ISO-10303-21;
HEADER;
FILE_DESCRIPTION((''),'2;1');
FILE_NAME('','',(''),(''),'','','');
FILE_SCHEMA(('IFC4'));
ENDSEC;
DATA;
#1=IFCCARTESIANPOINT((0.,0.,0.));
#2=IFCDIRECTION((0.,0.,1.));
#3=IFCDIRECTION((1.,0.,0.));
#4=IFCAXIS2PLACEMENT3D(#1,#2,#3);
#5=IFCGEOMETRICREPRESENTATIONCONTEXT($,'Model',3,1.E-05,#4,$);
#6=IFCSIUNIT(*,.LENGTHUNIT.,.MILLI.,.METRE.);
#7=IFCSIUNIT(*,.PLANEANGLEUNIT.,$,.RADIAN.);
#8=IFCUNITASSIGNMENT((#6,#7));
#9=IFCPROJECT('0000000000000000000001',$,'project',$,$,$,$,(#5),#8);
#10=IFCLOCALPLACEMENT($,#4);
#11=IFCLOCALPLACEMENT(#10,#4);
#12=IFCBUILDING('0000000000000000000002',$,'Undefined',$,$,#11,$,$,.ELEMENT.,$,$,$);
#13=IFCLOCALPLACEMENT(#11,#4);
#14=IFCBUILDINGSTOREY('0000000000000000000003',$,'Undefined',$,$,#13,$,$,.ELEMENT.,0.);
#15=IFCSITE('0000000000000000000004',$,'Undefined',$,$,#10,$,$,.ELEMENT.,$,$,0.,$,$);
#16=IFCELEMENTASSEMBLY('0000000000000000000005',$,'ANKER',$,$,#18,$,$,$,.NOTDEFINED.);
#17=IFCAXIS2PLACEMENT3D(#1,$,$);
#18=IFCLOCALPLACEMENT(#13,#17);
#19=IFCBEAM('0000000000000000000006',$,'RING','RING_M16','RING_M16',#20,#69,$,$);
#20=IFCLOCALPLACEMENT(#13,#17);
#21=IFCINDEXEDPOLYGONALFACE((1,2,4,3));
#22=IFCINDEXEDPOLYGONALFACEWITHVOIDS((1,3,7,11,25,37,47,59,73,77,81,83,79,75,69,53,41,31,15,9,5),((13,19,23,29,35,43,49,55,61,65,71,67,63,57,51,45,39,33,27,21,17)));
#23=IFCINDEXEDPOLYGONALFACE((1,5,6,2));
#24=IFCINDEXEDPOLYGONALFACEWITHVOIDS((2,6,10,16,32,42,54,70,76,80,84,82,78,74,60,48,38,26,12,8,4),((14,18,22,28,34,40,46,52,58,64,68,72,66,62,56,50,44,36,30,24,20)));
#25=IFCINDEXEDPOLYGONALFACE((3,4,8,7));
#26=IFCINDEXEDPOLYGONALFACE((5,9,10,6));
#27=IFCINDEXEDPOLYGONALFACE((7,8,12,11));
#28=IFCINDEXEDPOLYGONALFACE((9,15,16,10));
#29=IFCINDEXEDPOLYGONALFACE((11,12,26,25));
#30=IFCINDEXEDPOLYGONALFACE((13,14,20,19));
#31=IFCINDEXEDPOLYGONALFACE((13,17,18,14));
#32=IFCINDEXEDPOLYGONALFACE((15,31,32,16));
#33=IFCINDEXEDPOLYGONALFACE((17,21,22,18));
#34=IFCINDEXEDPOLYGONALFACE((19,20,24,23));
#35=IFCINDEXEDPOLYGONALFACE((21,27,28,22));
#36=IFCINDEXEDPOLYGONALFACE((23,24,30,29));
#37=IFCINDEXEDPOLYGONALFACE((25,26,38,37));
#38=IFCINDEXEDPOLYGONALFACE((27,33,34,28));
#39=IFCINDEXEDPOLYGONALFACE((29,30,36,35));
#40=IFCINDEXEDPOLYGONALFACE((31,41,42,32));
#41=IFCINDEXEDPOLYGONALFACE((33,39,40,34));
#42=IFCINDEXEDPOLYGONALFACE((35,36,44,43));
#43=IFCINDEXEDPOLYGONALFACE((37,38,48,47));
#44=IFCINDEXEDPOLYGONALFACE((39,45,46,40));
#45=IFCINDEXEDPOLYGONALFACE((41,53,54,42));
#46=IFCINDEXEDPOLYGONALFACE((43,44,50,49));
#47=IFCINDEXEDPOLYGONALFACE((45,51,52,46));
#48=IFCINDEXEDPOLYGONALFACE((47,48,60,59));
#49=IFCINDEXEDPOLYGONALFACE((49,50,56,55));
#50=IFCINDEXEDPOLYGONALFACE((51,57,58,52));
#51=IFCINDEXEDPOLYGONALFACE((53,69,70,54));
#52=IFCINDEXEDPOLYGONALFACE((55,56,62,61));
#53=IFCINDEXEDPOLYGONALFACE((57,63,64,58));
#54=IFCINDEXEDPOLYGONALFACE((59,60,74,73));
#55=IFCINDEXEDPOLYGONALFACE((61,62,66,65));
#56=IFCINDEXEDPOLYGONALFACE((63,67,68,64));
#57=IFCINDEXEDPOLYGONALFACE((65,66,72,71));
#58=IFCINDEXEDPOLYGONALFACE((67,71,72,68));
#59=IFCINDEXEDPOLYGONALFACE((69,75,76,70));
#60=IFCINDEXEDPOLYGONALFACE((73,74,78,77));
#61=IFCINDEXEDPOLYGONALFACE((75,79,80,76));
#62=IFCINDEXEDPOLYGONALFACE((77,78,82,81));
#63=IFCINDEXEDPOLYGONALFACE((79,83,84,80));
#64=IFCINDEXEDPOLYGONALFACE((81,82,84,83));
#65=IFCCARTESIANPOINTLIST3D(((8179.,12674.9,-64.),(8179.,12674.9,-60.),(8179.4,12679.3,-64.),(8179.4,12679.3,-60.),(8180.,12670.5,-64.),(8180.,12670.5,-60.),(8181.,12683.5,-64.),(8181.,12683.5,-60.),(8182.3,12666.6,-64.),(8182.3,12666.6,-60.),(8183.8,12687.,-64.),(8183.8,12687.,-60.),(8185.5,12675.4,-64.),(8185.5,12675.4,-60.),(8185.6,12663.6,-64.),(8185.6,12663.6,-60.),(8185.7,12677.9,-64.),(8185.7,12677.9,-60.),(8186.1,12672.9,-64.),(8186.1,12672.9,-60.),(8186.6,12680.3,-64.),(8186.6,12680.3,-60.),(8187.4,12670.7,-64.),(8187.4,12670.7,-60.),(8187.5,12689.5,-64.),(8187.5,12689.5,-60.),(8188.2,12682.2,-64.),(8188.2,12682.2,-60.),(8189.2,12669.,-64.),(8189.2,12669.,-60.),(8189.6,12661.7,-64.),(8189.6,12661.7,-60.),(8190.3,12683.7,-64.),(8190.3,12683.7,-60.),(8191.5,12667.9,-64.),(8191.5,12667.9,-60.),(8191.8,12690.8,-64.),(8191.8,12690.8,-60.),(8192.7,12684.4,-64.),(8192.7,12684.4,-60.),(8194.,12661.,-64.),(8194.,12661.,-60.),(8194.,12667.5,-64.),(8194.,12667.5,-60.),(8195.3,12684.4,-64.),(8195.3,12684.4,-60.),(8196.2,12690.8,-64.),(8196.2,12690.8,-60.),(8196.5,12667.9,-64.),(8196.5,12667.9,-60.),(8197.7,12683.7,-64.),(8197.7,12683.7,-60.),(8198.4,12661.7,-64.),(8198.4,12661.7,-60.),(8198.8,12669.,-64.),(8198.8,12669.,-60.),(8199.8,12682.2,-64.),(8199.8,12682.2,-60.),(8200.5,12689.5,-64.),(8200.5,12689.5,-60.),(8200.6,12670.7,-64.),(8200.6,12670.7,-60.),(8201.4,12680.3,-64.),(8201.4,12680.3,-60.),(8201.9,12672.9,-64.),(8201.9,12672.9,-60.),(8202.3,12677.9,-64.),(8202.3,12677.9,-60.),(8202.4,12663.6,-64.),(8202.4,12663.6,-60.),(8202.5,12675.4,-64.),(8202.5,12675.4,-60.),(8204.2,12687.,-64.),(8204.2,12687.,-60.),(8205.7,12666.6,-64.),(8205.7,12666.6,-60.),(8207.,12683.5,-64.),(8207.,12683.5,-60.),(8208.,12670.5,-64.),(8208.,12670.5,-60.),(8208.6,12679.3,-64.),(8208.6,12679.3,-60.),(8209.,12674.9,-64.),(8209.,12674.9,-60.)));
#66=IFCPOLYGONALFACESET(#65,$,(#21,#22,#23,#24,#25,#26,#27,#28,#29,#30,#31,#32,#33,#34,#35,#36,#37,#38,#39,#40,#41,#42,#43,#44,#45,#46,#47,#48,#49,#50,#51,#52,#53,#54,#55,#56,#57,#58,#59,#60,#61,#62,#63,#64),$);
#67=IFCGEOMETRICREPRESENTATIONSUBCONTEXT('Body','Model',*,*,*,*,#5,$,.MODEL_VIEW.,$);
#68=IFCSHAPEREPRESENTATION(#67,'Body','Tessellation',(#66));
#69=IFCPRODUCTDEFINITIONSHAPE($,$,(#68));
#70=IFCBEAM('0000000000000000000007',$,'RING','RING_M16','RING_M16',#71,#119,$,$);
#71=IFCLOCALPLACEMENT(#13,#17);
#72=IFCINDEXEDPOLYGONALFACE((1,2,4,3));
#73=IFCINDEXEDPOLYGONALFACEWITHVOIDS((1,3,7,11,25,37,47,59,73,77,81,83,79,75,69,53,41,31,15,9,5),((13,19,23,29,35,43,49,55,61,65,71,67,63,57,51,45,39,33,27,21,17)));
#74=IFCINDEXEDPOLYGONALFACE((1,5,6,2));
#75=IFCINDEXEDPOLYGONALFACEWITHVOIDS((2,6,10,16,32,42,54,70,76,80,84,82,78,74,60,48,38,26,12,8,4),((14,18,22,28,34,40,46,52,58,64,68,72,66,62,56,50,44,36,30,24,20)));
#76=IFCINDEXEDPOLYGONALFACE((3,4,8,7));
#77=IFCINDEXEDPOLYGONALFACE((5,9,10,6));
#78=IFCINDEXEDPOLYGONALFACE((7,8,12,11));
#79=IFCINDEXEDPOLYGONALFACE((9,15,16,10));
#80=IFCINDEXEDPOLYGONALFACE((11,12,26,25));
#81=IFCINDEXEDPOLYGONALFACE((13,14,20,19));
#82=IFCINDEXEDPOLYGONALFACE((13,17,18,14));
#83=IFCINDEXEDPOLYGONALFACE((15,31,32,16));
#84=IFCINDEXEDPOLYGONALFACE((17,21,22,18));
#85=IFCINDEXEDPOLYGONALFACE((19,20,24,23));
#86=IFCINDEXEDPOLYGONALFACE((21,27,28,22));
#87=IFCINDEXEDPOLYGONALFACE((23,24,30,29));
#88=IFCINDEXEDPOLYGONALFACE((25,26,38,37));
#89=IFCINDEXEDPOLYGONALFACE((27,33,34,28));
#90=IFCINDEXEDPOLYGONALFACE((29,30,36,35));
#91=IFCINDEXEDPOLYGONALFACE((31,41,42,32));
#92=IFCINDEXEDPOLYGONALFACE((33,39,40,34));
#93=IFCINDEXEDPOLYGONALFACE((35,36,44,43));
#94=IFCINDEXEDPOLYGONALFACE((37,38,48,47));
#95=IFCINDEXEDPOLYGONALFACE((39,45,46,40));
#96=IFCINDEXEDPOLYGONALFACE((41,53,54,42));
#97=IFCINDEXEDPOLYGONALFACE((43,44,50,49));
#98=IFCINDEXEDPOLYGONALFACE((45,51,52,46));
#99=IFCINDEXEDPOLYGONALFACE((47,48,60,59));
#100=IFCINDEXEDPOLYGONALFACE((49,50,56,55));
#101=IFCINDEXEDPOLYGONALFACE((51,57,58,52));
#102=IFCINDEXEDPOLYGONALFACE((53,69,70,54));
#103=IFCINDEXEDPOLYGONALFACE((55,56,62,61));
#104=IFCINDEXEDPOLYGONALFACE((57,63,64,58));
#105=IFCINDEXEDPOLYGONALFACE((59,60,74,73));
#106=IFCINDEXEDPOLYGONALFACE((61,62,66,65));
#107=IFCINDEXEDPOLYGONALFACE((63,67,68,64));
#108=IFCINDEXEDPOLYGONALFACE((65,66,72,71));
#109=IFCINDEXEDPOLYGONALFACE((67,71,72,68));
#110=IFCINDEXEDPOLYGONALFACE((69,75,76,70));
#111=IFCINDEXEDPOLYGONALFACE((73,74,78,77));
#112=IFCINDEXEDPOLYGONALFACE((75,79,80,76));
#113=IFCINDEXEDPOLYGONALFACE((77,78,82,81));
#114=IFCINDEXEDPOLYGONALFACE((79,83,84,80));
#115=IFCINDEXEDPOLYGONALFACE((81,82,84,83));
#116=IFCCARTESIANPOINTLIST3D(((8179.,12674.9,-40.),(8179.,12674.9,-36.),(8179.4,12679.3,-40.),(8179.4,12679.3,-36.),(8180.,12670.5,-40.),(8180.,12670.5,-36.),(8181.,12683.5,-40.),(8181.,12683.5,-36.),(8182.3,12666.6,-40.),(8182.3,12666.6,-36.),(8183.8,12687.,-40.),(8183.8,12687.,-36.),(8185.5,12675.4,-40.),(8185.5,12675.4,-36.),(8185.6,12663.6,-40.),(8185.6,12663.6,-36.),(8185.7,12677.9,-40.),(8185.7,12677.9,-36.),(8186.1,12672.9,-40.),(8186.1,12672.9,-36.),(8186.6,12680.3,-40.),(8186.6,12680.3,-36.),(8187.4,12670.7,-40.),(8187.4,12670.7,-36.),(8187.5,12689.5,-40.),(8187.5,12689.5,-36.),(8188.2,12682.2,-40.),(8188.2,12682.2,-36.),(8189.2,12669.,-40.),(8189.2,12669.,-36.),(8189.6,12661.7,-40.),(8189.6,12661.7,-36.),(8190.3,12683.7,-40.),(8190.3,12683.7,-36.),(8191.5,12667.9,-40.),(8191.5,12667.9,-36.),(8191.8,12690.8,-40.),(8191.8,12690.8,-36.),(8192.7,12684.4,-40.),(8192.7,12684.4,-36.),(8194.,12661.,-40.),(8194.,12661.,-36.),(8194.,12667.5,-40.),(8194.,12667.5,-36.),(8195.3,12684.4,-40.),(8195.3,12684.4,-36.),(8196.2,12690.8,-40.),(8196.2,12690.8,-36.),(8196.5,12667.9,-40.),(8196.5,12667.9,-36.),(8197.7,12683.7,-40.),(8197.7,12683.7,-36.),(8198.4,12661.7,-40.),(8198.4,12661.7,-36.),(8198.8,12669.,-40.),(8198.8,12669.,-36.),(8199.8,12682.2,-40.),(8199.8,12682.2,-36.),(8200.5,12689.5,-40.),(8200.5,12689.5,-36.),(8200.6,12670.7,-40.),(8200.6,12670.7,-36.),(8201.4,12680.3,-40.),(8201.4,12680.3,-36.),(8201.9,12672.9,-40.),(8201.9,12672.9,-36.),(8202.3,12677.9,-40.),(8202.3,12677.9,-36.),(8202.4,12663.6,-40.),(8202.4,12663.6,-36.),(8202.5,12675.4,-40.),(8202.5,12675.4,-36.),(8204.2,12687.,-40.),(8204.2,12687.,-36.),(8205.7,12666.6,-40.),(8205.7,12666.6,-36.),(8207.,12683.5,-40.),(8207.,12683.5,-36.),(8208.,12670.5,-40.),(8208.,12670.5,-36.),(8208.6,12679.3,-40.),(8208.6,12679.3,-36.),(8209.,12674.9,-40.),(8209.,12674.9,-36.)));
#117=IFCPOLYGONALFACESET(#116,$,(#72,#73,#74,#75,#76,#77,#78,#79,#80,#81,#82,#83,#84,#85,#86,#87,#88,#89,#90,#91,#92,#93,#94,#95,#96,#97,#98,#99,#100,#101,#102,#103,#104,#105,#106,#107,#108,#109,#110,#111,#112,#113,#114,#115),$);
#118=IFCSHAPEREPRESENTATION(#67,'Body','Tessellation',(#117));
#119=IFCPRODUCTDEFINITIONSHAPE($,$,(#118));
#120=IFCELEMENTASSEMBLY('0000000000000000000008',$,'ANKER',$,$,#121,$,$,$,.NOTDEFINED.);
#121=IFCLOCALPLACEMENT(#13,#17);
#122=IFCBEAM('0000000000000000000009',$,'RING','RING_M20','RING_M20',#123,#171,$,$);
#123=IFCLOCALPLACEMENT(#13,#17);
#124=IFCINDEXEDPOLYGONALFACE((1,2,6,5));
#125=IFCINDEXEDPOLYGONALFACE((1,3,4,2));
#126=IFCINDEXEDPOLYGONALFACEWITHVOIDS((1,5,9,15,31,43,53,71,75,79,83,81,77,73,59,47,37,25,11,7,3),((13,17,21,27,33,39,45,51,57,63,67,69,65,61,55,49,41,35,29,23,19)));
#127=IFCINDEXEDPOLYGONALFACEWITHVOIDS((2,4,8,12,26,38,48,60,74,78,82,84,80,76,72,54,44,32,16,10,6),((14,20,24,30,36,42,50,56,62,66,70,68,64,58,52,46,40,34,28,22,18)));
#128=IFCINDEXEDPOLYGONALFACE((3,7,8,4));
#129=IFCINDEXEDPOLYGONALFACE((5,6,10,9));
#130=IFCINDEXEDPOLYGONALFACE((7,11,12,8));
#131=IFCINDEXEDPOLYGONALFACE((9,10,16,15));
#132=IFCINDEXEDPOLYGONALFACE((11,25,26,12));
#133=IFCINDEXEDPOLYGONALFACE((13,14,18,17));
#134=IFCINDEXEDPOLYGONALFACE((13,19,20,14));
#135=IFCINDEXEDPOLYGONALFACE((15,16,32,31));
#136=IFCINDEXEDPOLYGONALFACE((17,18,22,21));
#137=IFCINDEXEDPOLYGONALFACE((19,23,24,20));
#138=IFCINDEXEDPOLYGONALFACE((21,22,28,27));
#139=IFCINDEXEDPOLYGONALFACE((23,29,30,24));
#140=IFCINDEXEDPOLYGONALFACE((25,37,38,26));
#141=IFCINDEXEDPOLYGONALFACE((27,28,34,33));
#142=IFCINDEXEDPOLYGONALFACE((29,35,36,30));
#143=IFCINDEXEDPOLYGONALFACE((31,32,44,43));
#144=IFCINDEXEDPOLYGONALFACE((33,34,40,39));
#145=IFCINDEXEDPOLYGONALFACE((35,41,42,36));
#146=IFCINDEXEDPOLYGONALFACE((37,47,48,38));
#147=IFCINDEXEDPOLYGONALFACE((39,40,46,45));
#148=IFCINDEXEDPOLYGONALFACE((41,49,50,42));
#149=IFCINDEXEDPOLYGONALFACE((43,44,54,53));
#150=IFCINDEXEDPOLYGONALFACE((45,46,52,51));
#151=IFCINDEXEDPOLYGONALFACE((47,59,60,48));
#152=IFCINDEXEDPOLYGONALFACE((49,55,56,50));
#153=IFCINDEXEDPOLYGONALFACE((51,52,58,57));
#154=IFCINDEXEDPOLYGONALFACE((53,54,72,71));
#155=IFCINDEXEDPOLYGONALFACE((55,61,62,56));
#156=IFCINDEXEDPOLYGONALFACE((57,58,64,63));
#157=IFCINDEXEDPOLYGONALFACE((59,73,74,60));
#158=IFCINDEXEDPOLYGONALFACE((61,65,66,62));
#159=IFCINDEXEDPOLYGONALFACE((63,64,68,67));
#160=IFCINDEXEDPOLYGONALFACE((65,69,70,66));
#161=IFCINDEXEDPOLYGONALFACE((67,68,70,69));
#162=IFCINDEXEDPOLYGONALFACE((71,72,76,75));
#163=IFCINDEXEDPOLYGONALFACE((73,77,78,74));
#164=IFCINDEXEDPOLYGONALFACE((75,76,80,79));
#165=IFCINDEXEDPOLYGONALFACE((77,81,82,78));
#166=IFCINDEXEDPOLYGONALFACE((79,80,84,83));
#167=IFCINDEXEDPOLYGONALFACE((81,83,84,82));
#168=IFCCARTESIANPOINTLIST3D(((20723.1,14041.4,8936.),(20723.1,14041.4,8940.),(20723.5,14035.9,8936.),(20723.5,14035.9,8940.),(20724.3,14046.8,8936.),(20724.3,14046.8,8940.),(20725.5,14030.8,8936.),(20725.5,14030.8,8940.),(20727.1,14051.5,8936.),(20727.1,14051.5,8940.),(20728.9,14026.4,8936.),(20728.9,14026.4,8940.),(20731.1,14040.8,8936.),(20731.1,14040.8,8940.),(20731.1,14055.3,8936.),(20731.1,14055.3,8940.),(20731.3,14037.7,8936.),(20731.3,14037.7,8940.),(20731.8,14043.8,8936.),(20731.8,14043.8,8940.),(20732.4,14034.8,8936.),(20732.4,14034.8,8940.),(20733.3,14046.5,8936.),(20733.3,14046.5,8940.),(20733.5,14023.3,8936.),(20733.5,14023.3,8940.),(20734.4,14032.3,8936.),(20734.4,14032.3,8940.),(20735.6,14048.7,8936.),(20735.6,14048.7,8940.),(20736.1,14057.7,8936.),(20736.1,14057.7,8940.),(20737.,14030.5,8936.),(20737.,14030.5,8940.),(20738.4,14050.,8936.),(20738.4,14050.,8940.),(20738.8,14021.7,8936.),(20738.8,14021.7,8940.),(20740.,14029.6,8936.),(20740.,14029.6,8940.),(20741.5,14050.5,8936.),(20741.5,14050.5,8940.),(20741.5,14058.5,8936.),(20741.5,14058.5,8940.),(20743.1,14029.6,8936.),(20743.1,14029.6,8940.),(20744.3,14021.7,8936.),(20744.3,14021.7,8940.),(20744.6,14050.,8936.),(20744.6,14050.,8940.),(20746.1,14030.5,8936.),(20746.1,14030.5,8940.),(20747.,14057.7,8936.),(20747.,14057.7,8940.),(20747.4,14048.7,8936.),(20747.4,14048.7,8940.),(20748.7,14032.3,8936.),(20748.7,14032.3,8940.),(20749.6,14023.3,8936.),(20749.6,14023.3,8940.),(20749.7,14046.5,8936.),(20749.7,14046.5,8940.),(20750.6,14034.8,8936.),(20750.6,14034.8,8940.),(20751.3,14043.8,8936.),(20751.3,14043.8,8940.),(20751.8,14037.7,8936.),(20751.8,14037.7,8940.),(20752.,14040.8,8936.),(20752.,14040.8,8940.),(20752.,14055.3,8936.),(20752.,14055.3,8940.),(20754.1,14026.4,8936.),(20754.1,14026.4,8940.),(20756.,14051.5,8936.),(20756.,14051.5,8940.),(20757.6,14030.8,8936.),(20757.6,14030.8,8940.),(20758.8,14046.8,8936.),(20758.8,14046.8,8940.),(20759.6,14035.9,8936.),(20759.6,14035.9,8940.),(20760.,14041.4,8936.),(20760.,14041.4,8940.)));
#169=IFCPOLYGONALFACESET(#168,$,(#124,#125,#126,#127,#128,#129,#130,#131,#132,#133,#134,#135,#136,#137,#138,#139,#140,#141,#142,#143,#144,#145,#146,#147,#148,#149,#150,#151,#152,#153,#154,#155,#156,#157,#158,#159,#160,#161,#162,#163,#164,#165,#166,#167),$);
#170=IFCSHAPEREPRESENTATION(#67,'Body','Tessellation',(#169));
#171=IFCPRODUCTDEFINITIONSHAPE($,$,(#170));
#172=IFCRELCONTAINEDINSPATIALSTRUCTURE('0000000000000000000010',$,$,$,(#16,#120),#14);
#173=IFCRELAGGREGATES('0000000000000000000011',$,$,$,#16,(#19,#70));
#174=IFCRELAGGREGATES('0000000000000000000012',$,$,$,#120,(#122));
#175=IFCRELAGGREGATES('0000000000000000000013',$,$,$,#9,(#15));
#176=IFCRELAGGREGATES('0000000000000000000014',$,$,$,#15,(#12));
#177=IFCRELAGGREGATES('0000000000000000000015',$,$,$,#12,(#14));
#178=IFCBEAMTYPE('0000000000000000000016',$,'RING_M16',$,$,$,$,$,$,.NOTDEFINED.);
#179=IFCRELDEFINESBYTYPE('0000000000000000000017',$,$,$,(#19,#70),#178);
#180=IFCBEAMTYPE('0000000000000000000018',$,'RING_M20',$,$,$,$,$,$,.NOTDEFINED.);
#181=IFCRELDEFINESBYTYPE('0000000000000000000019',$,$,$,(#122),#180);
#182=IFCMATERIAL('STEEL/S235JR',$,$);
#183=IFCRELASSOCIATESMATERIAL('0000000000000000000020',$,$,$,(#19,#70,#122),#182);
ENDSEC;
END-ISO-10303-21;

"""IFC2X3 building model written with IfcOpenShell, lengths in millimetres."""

from ifc_helpers import new_model, si_unit, frame, origin_with_axes, origin_2d_with_axis, place, context, subcontext, project, spatial, hollow_circle, extrude, material, type_object, element, aggregate, save


model = new_model("IFC2X3")

# Units and contexts
model_context = context("Model", 3, precision=1e-05, world=origin_with_axes())
body_context = subcontext(model_context, "Body", "Model", "MODEL_VIEW")
ifc_project = project(units=[si_unit("LENGTHUNIT", "METRE", prefix="MILLI"), si_unit("PLANEANGLEUNIT", "RADIAN")], contexts=[model_context])

# Site, building, storey
site_placement = place(None, origin_with_axes())
site = spatial("IfcSite", under=ifc_project, at=site_placement, Name="Undefined", CompositionType="ELEMENT", RefElevation=0.0)
building_placement = place(site_placement, origin_with_axes())
building = spatial("IfcBuilding", under=site, at=building_placement, Name="Undefined", CompositionType="ELEMENT")
storey_placement = place(building_placement, origin_with_axes())
storey = spatial("IfcBuildingStorey", under=building, at=storey_placement, Name="Undefined", CompositionType="ELEMENT", Elevation=0.0)

# Shared definitions
ifc_material = material(Name="STEEL/S235JR")

# Element assemblies, beams
beam_type_1 = type_object("IfcBeamType", Name="RING_M16", PredefinedType="NOTDEFINED")
assembly_1_placement = place(storey_placement, frame((8194.0, 12676.0, 10.0), z_axis=(1.0, 0.0, 0.0), x_axis=(0.0, 0.0, -1.0)))
assembly_1 = element("IfcElementAssembly", 1, at=assembly_1_placement, inside=storey, Name="ANKER", PredefinedType="NOTDEFINED")
beam_1_placement = place(storey_placement, frame((8194.0, 12676.0, -60.0), z_axis=(1.0, 0.0, 0.0), x_axis=(0.0, 0.0, -1.0)))
beam_1 = element("IfcBeam", 2, at=beam_1_placement, type_object=beam_type_1, material=ifc_material, Name="RING", Description="RING_M16", ObjectType="RING_M16", context=body_context, shape_type="SweptSolid", body=[
    extrude(hollow_circle(Radius=15.0, WallThickness=6.5, at=origin_2d_with_axis()), frame((4.0, 0.0, 0.0), z_axis=(-1.0, 0.0, 0.0), x_axis=(0.0, -1.0, 0.0)), (0.0, 0.0, 1.0), 4.0),
])
beam_2_placement = place(storey_placement, frame((8194.0, 12676.0, -36.0), z_axis=(1.0, 0.0, 0.0), x_axis=(0.0, 0.0, -1.0)))
beam_2 = element("IfcBeam", 3, at=beam_2_placement, type_object=beam_type_1, material=ifc_material, Name="RING", Description="RING_M16", ObjectType="RING_M16", context=body_context, shape_type="SweptSolid", body=[
    extrude(hollow_circle(Radius=15.0, WallThickness=6.5, at=origin_2d_with_axis()), frame((4.0, 0.0, 0.0), z_axis=(-1.0, 0.0, 0.0), x_axis=(0.0, -1.0, 0.0)), (0.0, 0.0, 1.0), 4.0),
])
aggregate(assembly_1, [beam_1, beam_2])
assembly_2_placement = place(storey_placement, frame((20741.5, 14040.0, 9010.0), z_axis=(0.0, 1.0, 0.0), x_axis=(0.0, 0.0, -1.0)))
assembly_2 = element("IfcElementAssembly", 4, at=assembly_2_placement, inside=storey, Name="ANKER", PredefinedType="NOTDEFINED")
beam_type_2 = type_object("IfcBeamType", Name="RING_M20", PredefinedType="NOTDEFINED")
beam_3_placement = place(storey_placement, frame((20741.5, 14040.0, 8940.0), z_axis=(-1.0, 0.0, 0.0), x_axis=(0.0, 0.0, -1.0)))
beam_3 = element("IfcBeam", 5, at=beam_3_placement, type_object=beam_type_2, material=ifc_material, Name="RING", Description="RING_M20", ObjectType="RING_M20", context=body_context, shape_type="SweptSolid", body=[
    extrude(hollow_circle(Radius=18.5, WallThickness=8.0, at=origin_2d_with_axis()), frame((4.0, 0.0, 0.0), z_axis=(-1.0, 0.0, 0.0), x_axis=(0.0, -1.0, 0.0)), (0.0, 0.0, 1.0), 4.0),
])
aggregate(assembly_2, [beam_3])

save(model, "model.ifc")
